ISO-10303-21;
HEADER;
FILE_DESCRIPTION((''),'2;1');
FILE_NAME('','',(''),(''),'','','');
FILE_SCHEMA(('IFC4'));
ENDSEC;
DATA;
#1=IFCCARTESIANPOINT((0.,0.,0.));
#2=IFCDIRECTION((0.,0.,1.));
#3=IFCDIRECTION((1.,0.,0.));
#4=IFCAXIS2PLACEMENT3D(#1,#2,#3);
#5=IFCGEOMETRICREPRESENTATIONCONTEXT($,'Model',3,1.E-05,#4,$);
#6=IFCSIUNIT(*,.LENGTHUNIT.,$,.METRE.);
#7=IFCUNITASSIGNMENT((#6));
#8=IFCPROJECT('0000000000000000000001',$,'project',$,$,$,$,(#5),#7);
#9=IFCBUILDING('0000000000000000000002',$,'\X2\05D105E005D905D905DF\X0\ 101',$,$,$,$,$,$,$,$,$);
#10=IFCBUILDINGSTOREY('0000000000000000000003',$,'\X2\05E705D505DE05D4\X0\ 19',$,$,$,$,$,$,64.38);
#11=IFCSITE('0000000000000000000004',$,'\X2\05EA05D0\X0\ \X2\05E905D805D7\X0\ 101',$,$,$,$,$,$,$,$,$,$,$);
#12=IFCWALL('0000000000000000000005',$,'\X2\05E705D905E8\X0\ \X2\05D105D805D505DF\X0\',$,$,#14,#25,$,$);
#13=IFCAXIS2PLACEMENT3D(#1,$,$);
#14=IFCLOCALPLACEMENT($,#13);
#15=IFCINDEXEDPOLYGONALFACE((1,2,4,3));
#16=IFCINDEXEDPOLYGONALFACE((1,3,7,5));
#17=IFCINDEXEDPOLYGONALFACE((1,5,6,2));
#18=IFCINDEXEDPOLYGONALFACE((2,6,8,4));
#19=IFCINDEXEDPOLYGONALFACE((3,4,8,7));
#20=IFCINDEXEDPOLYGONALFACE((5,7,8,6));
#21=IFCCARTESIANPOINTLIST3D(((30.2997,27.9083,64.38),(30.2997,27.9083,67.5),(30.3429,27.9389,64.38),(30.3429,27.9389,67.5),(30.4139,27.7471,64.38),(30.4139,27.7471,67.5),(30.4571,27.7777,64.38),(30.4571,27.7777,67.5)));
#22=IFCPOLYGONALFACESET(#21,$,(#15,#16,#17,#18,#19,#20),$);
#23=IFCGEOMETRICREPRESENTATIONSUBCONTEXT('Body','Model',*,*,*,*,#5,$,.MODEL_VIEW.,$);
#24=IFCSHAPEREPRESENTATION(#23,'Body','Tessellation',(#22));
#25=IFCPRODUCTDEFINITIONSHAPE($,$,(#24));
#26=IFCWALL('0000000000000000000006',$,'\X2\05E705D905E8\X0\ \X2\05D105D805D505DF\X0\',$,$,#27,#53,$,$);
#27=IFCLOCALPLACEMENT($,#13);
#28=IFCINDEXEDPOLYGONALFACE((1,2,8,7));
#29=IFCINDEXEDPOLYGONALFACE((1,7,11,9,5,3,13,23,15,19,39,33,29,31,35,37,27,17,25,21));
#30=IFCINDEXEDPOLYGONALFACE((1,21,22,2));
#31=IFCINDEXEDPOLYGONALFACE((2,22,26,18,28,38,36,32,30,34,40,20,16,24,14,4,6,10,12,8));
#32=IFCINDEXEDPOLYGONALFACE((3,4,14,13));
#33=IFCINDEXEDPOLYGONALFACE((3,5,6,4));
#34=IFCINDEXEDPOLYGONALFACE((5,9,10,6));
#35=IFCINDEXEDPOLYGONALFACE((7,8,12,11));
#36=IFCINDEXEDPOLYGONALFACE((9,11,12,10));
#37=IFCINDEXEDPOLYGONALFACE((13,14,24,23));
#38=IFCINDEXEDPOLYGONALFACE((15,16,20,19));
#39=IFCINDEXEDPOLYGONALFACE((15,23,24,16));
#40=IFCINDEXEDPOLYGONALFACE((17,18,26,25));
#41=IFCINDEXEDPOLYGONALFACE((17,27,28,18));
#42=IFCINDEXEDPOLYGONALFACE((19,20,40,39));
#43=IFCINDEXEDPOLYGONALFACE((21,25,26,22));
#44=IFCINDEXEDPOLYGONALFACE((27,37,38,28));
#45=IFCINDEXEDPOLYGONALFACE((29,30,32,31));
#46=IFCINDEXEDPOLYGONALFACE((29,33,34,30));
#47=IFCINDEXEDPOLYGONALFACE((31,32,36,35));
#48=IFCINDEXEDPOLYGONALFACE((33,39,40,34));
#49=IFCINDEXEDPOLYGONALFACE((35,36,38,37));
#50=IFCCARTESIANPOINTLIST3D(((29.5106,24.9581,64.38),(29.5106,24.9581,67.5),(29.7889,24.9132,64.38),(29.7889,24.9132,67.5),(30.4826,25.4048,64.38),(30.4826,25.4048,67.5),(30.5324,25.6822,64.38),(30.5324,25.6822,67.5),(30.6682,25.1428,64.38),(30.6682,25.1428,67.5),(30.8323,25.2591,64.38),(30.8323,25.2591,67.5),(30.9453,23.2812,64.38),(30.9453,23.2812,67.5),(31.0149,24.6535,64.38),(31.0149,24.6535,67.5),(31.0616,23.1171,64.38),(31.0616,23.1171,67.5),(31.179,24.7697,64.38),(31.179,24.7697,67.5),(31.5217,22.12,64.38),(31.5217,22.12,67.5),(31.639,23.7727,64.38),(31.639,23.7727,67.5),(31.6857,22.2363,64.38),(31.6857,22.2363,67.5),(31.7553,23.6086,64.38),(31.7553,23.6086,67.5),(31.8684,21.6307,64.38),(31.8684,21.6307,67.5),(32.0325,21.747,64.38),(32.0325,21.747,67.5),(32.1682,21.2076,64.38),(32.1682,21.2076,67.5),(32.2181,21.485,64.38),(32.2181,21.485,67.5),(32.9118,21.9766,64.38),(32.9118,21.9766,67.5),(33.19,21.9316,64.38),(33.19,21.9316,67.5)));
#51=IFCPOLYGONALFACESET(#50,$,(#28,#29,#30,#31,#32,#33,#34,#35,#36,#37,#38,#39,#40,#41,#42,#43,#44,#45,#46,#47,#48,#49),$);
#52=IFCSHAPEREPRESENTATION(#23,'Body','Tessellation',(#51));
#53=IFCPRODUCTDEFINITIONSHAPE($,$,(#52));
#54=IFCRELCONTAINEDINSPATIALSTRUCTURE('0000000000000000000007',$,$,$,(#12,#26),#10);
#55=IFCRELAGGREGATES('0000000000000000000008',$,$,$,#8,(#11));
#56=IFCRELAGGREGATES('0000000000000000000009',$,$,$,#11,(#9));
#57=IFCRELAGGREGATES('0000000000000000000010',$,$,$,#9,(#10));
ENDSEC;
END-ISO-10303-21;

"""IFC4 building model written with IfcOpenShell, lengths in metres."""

from ifc_helpers import new_model, si_unit, frame, origin_with_axes, context, subcontext, project, spatial, polyline, outline, extrude, element, save


model = new_model("IFC4")

# Units and contexts
model_context = context("Model", 3, precision=1e-05, world=origin_with_axes())
body_context = subcontext(model_context, "Body", "Model", "MODEL_VIEW")
ifc_project = project(units=[si_unit("LENGTHUNIT", "METRE")], contexts=[model_context])

# Site, building, storey
site = spatial("IfcSite", under=ifc_project, Name="תא שטח 101")
building = spatial("IfcBuilding", under=site, Name="בניין 101")
storey = spatial("IfcBuildingStorey", under=building, Name="קומה 19", Elevation=64.38)

# Walls
element("IfcWall", 1, inside=storey, Name="קיר בטון", context=body_context, shape_type="SweptSolid", body=[
    extrude(outline(polyline([(30.3429, 27.9389), (30.2997, 27.9083), (30.4139, 27.7471), (30.4571, 27.7777), (30.3429, 27.9389)])), frame((0.0, 0.0, 64.38)), (0.0, 0.0, 1.0), 3.12),
])
element("IfcWall", 2, inside=storey, Name="קיר בטון", context=body_context, shape_type="SweptSolid", body=[
    extrude(outline(polyline([(30.4826, 25.4048), (30.6682, 25.1428), (30.8323, 25.2591), (30.5324, 25.6822), (29.5106, 24.9581), (31.5217, 22.12), (31.6857, 22.2363), (31.0616, 23.1171), (31.7553, 23.6086), (32.9118, 21.9766), (32.2181, 21.485), (32.0325, 21.747), (31.8684, 21.6307), (32.1682, 21.2076), (33.19, 21.9316), (31.179, 24.7697), (31.0149, 24.6535), (31.639, 23.7727), (30.9453, 23.2812), (29.7889, 24.9132), (30.4826, 25.4048)])), frame((0.0, 0.0, 64.38)), (0.0, 0.0, 1.0), 3.12),
])

save(model, "model.ifc")
